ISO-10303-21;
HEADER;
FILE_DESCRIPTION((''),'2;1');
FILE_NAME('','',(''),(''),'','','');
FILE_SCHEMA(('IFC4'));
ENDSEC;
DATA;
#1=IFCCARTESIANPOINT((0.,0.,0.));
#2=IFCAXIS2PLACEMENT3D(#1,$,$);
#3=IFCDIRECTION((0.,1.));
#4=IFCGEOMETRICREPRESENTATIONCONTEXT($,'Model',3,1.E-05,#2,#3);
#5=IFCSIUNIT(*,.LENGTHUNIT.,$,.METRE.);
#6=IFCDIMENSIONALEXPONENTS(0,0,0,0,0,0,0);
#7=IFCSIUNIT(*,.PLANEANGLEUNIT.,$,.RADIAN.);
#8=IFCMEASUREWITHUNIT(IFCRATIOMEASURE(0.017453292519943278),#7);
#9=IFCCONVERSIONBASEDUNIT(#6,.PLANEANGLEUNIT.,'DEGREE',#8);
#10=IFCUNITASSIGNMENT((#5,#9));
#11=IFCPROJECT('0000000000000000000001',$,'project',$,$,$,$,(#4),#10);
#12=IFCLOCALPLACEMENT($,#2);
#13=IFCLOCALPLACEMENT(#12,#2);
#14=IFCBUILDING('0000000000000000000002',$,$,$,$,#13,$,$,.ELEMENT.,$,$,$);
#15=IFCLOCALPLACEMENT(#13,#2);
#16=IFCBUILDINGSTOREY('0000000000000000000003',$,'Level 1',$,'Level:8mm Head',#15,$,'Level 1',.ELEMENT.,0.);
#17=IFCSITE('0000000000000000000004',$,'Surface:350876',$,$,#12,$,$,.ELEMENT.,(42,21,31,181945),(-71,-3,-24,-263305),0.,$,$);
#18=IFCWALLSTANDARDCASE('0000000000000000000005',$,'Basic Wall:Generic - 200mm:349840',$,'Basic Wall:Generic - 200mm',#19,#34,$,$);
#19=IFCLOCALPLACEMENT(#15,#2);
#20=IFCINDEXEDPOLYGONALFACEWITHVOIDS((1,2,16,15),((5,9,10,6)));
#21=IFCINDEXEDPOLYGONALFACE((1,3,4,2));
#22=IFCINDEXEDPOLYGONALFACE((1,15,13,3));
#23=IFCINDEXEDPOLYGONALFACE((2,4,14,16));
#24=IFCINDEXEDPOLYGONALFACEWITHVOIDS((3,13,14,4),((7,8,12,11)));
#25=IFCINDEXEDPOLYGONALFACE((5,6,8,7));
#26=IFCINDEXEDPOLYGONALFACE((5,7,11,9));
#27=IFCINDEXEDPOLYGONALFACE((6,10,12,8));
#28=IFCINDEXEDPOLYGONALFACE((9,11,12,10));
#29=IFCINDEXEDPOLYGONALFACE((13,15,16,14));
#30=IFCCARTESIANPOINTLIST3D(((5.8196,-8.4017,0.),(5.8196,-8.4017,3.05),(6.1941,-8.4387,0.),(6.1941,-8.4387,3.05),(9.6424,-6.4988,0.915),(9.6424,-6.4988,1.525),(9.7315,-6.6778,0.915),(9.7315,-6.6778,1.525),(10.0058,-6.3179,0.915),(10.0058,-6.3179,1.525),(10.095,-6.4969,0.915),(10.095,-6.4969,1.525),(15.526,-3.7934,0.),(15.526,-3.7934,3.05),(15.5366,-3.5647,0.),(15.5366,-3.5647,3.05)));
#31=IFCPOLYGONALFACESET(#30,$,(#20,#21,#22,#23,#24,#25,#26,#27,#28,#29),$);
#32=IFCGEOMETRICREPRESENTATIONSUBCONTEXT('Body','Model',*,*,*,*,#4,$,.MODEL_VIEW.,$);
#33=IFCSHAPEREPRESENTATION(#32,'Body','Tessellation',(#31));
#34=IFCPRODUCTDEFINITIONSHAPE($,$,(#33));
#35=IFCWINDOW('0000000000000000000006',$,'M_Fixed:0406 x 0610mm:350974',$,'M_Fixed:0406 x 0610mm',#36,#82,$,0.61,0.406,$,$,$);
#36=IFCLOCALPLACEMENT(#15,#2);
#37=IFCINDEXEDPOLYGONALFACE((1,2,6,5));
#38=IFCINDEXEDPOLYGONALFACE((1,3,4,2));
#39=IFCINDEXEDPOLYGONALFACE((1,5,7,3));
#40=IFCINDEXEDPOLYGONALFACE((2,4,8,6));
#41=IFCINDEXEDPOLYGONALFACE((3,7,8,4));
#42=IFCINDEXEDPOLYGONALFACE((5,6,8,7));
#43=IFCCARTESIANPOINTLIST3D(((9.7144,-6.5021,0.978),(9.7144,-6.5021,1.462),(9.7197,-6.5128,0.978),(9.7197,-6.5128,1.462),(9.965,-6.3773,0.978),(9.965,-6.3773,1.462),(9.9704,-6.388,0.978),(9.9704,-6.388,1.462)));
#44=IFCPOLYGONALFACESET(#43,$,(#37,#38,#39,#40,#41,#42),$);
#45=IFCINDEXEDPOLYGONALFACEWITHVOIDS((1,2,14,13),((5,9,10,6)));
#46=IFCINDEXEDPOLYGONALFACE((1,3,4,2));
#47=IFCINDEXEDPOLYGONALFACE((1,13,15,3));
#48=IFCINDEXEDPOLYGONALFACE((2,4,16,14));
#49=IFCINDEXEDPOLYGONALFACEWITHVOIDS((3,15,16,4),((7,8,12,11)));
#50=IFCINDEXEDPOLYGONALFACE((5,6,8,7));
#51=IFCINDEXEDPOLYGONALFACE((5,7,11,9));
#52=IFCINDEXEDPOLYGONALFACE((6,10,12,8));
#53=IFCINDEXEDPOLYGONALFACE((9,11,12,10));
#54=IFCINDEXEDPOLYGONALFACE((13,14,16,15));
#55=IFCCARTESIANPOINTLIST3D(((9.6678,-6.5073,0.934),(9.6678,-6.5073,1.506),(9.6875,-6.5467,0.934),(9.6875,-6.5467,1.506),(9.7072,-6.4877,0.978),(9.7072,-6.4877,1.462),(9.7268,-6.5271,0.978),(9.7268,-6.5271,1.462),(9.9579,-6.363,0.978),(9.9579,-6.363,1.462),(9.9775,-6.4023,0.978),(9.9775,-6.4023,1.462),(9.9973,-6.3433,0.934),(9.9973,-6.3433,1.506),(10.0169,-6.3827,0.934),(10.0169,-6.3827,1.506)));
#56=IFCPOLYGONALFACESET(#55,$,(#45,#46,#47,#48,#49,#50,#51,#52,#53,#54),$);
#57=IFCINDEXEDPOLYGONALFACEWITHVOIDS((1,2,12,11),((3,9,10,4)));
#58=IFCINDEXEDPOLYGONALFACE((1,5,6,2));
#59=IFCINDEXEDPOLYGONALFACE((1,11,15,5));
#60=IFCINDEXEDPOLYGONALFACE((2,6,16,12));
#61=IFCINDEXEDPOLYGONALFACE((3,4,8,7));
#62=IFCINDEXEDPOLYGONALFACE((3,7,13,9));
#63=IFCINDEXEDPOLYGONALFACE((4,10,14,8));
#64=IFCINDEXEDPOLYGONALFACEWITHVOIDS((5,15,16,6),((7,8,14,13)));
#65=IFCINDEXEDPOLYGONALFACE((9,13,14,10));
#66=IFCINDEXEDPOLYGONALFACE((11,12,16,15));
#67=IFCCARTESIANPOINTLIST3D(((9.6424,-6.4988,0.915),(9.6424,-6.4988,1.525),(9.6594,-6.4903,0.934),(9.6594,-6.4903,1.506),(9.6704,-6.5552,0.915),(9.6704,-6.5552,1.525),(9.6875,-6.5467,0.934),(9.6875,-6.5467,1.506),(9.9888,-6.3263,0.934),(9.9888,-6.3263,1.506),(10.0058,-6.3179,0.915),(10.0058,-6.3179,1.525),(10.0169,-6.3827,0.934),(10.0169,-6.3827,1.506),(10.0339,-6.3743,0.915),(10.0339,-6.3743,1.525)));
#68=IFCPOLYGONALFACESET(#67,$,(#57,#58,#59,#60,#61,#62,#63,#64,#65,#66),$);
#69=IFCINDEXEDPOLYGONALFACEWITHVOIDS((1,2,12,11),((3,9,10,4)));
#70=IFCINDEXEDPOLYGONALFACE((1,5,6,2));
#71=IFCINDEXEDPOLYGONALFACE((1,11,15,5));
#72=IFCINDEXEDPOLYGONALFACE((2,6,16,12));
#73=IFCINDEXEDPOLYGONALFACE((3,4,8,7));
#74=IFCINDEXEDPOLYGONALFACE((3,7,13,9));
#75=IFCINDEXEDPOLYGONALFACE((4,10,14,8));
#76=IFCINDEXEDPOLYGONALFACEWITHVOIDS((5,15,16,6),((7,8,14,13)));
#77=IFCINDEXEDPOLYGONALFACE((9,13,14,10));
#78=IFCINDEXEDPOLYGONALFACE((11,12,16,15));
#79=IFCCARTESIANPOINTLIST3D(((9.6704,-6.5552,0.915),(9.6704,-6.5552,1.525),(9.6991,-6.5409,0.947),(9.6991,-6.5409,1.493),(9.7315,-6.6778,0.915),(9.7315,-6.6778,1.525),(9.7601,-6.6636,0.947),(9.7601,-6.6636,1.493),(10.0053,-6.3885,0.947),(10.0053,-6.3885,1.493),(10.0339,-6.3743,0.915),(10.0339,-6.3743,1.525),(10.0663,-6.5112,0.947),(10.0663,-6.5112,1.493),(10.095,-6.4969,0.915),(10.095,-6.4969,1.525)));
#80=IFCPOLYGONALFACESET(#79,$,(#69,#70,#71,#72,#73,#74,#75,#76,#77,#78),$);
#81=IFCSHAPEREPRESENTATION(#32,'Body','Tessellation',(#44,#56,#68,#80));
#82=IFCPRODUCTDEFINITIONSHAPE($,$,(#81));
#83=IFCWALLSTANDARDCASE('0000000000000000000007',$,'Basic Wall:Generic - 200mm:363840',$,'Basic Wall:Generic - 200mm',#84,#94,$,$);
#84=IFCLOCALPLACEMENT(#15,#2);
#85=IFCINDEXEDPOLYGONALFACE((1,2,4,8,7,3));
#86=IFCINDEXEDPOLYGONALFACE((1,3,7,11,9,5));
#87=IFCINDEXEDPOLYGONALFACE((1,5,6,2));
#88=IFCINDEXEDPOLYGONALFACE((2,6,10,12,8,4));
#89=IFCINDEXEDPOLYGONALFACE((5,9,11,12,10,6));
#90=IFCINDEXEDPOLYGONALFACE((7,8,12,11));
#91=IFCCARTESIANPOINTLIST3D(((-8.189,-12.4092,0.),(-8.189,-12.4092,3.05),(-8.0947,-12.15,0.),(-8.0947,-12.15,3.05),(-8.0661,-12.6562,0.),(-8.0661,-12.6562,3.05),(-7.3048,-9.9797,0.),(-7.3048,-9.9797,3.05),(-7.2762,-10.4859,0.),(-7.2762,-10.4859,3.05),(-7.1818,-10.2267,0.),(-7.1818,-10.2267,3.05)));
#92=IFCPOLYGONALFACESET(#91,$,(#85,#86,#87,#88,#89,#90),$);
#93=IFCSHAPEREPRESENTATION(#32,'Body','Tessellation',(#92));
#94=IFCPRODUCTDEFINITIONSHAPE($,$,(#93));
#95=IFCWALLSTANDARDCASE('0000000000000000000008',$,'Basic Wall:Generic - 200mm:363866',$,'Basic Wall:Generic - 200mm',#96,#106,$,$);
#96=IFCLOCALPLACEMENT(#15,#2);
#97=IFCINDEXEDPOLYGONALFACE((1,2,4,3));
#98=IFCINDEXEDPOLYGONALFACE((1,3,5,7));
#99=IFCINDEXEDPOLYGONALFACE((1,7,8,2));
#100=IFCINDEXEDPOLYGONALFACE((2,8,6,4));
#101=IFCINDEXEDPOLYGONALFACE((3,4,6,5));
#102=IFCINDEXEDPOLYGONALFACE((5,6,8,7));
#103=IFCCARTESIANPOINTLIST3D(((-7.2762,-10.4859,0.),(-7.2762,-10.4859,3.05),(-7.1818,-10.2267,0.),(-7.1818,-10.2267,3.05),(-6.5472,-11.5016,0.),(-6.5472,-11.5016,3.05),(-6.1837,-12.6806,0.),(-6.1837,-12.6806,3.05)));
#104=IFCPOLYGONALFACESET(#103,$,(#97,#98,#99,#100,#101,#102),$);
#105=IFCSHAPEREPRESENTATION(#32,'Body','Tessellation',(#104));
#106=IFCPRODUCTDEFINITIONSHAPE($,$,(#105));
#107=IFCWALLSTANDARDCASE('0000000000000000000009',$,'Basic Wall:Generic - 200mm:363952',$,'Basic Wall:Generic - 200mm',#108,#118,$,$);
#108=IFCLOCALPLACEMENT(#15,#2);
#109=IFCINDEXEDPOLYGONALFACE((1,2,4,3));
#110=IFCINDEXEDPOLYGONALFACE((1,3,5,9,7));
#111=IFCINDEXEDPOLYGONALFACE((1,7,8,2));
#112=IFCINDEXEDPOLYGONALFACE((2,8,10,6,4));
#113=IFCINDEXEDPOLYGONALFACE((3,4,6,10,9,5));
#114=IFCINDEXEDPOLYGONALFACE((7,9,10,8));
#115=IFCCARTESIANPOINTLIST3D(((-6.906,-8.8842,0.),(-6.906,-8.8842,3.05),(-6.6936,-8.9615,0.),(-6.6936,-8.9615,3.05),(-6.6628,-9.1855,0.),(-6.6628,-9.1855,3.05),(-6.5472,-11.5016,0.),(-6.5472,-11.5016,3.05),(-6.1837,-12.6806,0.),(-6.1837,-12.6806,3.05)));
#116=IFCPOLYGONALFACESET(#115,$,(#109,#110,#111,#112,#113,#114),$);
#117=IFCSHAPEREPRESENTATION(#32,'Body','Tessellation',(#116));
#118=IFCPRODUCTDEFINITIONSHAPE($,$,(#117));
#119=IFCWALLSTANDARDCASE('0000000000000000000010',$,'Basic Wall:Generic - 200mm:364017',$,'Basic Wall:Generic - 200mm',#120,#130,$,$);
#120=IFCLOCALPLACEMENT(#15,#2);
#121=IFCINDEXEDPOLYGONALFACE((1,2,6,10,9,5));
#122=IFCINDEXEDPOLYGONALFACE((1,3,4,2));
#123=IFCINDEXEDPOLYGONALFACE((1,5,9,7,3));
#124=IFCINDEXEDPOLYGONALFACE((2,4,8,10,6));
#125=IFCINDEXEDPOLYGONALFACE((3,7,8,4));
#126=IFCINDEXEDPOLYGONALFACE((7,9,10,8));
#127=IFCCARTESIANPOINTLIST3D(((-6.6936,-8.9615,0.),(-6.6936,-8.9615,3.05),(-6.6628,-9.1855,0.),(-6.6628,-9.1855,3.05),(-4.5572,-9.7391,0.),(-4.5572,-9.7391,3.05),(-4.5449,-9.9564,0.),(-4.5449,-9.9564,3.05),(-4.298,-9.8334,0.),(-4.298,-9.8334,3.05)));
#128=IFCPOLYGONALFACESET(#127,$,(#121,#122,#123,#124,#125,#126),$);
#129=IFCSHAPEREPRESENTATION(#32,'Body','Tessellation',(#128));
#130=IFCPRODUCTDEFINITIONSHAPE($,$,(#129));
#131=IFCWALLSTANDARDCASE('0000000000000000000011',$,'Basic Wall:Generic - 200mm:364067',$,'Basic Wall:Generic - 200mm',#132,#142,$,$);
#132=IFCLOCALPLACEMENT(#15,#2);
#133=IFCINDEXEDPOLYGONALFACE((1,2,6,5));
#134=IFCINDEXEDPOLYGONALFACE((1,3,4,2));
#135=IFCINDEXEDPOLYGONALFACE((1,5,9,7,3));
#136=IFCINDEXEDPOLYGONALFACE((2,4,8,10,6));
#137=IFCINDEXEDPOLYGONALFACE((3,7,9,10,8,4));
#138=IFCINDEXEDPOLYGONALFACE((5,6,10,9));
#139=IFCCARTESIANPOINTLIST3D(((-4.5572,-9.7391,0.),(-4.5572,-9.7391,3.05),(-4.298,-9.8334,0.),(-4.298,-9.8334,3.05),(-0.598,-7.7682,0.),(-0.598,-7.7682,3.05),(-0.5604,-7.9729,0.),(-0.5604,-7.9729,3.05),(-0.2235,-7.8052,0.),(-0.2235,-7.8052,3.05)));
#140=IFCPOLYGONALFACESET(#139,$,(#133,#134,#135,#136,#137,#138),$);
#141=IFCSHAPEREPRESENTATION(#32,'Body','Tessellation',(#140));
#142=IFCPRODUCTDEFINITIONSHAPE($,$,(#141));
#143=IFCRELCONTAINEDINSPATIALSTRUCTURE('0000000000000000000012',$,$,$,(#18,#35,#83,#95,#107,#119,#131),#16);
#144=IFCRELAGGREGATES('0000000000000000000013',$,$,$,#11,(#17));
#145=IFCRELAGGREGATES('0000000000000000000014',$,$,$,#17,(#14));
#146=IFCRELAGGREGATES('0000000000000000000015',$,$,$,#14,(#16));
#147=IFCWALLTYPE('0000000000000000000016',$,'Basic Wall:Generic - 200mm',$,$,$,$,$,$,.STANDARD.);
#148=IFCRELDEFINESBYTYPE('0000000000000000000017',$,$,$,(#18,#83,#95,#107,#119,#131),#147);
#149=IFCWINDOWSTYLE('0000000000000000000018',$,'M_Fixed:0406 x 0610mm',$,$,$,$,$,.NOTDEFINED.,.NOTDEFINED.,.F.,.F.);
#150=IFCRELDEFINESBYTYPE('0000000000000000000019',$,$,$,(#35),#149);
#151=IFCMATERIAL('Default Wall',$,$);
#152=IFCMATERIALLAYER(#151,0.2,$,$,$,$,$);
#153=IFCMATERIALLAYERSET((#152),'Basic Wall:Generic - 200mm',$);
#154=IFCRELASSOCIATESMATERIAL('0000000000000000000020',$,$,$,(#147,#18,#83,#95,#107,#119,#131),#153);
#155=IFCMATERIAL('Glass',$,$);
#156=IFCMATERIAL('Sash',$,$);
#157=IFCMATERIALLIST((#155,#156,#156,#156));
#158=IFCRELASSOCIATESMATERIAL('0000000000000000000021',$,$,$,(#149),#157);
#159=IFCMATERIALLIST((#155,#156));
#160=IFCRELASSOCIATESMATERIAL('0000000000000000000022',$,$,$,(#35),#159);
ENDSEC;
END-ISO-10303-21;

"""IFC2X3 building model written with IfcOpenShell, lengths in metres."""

from ifc_helpers import new_model, entity, si_unit, converted_unit, direction, frame, frame_2d, origin, place, context, subcontext, project, spatial, polyline, rectangle, outline, extrude, source, transform, mapped, material, material_list, layer, layer_set, layer_usage, type_object, type_shapes, element, fill, save


model = new_model("IFC2X3")

# Units and contexts
model_context = context("Model", 3, precision=1e-05, world=origin(), true_north=direction((0.0, 1.0)))
body_context = subcontext(model_context, "Body", "Model", "MODEL_VIEW")
ifc_project = project(units=[si_unit("LENGTHUNIT", "METRE"), converted_unit("PLANEANGLEUNIT", "DEGREE", entity("IfcRatioMeasure", 0.017453292519943278), si_unit("PLANEANGLEUNIT", "RADIAN"), dimensions=[0, 0, 0, 0, 0, 0, 0])], contexts=[model_context])

# Site, building, storey
site_placement = place(None, origin())
site = spatial("IfcSite", under=ifc_project, at=site_placement, Name="Surface:350876", CompositionType="ELEMENT", RefLatitude=(42, 21, 31, 181945), RefLongitude=(-71, -3, -24, -263305), RefElevation=0.0)
building_placement = place(site_placement, origin())
building = spatial("IfcBuilding", under=site, at=building_placement, CompositionType="ELEMENT")
storey_placement = place(building_placement, origin())
storey = spatial("IfcBuildingStorey", under=building, at=storey_placement, Name="Level 1", ObjectType="Level:8mm Head", LongName="Level 1", CompositionType="ELEMENT", Elevation=0.0)

# Wall, opening, window
ifc_material_1 = material(Name="Default Wall")
ifc_layer_1 = layer(ifc_material_1, 0.2)
ifc_layer_set_1 = layer_set([ifc_layer_1], Name="Basic Wall:Generic - 200mm")
ifc_layer_usage_1 = layer_usage(ifc_layer_set_1, "AXIS2", "NEGATIVE", 0.1)
wall_type_1 = type_object("IfcWallType", Name="Basic Wall:Generic - 200mm", PredefinedType="STANDARD", material=ifc_layer_set_1)
wall_1_placement = place(storey_placement, frame((5.8642, -8.4912, 0.0), z_axis=(0.0, 0.0, 1.0), x_axis=(0.895217, 0.44563, 0.0)))
wall_1 = element("IfcWallStandardCase", 1, at=wall_1_placement, inside=storey, type_object=wall_type_1, material=ifc_layer_usage_1, Name="Basic Wall:Generic - 200mm:349840", ObjectType="Basic Wall:Generic - 200mm", context=body_context, shape_type="SweptSolid", body=[
    extrude(outline(polyline([(10.7429, -0.1), (10.8544, 0.1), (10.6254, 0.1), (9.4635, 0.1), (9.2633, 0.1), (0.1742, 0.1), (0.0, 0.1), (0.3188, -0.1), (10.7429, -0.1)])), origin(), (0.0, 0.0, 1.0), 3.05),
])
opening_1_placement = place(wall_1_placement, frame((4.2702, -0.1, 0.915)))
opening_1 = element("IfcOpeningElement", 2, at=opening_1_placement, cuts=wall_1, ObjectType="Opening", context=body_context, shape_type="SweptSolid", body=[
    extrude(rectangle(XDim=0.61, YDim=0.406, at=frame_2d((0.305, 0.203), x_axis=(1.0, 0.0))), frame((0.0, 0.0, 0.0), z_axis=(0.0, 1.0, 0.0), x_axis=(0.0, 0.0, 1.0)), (0.0, 0.0, 1.0), 0.2),
])
ifc_material_2 = material(Name="Glass")
ifc_material_3 = material(Name="Sash")
ifc_material_list_1 = material_list([ifc_material_2, ifc_material_3])
ifc_material_list_2 = material_list([ifc_material_2, ifc_material_3, ifc_material_3, ifc_material_3])
window_style = type_object("IfcWindowStyle", Name="M_Fixed:0406 x 0610mm", ConstructionType="NOTDEFINED", OperationType="NOTDEFINED", ParameterTakesPrecedence=False, Sizeable=False, material=ifc_material_list_2)
shared_shape_1 = source(origin(), body_context, "Body", "SweptSolid", [
    extrude(rectangle(XDim=0.012, YDim=0.28, at=frame_2d((0.0, 0.0), x_axis=(1.0, 0.0))), frame((0.203, 0.159, 0.063), z_axis=(0.0, 0.0, 1.0), x_axis=(0.0, -1.0, 0.0)), (0.0, 0.0, 1.0), 0.484),
    extrude(outline(polyline([(-0.184, -0.286), (0.184, -0.286), (0.184, 0.286), (-0.184, 0.286), (-0.184, -0.286)]), holes=[polyline([(-0.14, -0.242), (-0.14, 0.242), (0.14, 0.242), (0.14, -0.242), (-0.14, -0.242)])]), frame((0.203, 0.137, 0.305), z_axis=(0.0, 1.0, 0.0), x_axis=(1.0, 0.0, 0.0)), (0.0, 0.0, 1.0), 0.044),
    extrude(outline(polyline([(-0.203, -0.305), (0.203, -0.305), (0.203, 0.305), (-0.203, 0.305), (-0.203, -0.305)]), holes=[polyline([(-0.184, -0.286), (-0.184, 0.286), (0.184, 0.286), (0.184, -0.286), (-0.184, -0.286)])]), frame((0.203, 0.137, 0.305), z_axis=(0.0, 1.0, 0.0), x_axis=(1.0, 0.0, 0.0)), (0.0, 0.0, 1.0), 0.063),
    extrude(outline(polyline([(-0.203, -0.305), (0.203, -0.305), (0.203, 0.305), (-0.203, 0.305), (-0.203, -0.305)]), holes=[polyline([(-0.171, -0.273), (-0.171, 0.273), (0.171, 0.273), (0.171, -0.273), (-0.171, -0.273)])]), frame((0.203, 0.0, 0.305), z_axis=(0.0, 1.0, 0.0), x_axis=(1.0, 0.0, 0.0)), (0.0, 0.0, 1.0), 0.137),
])
type_shapes(window_style, [shared_shape_1])
window_1_placement = place(opening_1_placement, origin())
window_1 = element("IfcWindow", 3, at=window_1_placement, inside=storey, type_object=window_style, material=ifc_material_list_1, Name="M_Fixed:0406 x 0610mm:350974", ObjectType="M_Fixed:0406 x 0610mm", OverallHeight=0.61, OverallWidth=0.406, context=body_context, shape_type="MappedRepresentation", body=[
    mapped(shared_shape_1, transform((0.0, 0.0, 0.0), scale=1.0)),
])
fill(opening_1, window_1)

# Walls
ifc_layer_usage_2 = layer_usage(ifc_layer_set_1, "AXIS2", "NEGATIVE", 0.1)
wall_2_placement = place(storey_placement, frame((-8.1601, -12.622, 0.0), z_axis=(0.0, 0.0, 1.0), x_axis=(0.34202, 0.939693, 0.0)))
element("IfcWallStandardCase", 4, at=wall_2_placement, inside=storey, type_object=wall_type_1, material=ifc_layer_usage_2, Name="Basic Wall:Generic - 200mm:363840", ObjectType="Basic Wall:Generic - 200mm", context=body_context, shape_type="SweptSolid", body=[
    extrude(outline(polyline([(2.5855, -0.1), (2.7755, 0.1), (0.4659, 0.1), (0.19, 0.1), (0.0, -0.1), (2.3096, -0.1), (2.5855, -0.1)])), origin(), (0.0, 0.0, 1.0), 3.05),
])
ifc_layer_usage_3 = layer_usage(ifc_layer_set_1, "AXIS2", "NEGATIVE", 0.1)
wall_3_placement = place(storey_placement, frame((-7.2713, -10.2712, 0.0), z_axis=(0.0, 0.0, 1.0), x_axis=(0.44563, -0.895217, 0.0)))
element("IfcWallStandardCase", 5, at=wall_3_placement, inside=storey, type_object=wall_type_1, material=ifc_layer_usage_3, Name="Basic Wall:Generic - 200mm:363866", ObjectType="Basic Wall:Generic - 200mm", context=body_context, shape_type="SweptSolid", body=[
    extrude(outline(polyline([(2.6416, -0.1), (1.4241, 0.1), (0.0, 0.1), (0.19, -0.1), (2.6416, -0.1)])), origin(), (0.0, 0.0, 1.0), 3.05),
])
ifc_layer_usage_4 = layer_usage(ifc_layer_set_1, "AXIS2", "NEGATIVE", 0.1)
wall_4_placement = place(storey_placement, frame((-6.2828, -12.6942, 0.0), z_axis=(0.0, 0.0, 1.0), x_axis=(-0.135824, 0.990733, 0.0)))
element("IfcWallStandardCase", 6, at=wall_4_placement, inside=storey, type_object=wall_type_1, material=ifc_layer_usage_4, Name="Basic Wall:Generic - 200mm:363952", ObjectType="Basic Wall:Generic - 200mm", context=body_context, shape_type="SweptSolid", body=[
    extrude(outline(polyline([(3.7539, -0.1), (3.8594, 0.1), (1.2175, 0.1), (0.0, -0.1), (3.5278, -0.1), (3.7539, -0.1)])), origin(), (0.0, 0.0, 1.0), 3.05),
])
ifc_layer_usage_5 = layer_usage(ifc_layer_set_1, "AXIS2", "NEGATIVE", 0.1)
wall_5_placement = place(storey_placement, frame((-6.7278, -9.0555, 0.0), z_axis=(0.0, 0.0, 1.0), x_axis=(0.939693, -0.34202, 0.0)))
element("IfcWallStandardCase", 7, at=wall_5_placement, inside=storey, type_object=wall_type_1, material=ifc_layer_usage_5, Name="Basic Wall:Generic - 200mm:364017", ObjectType="Basic Wall:Generic - 200mm", context=body_context, shape_type="SweptSolid", body=[
    extrude(outline(polyline([(2.3593, -0.1), (2.5493, 0.1), (2.2734, 0.1), (0.0, 0.1), (0.1055, -0.1), (2.3593, -0.1)])), origin(), (0.0, 0.0, 1.0), 3.05),
])
ifc_layer_usage_6 = layer_usage(ifc_layer_set_1, "AXIS2", "NEGATIVE", 0.1)
wall_6_placement = place(storey_placement, frame((-4.5126, -9.8286, 0.0), z_axis=(0.0, 0.0, 1.0), x_axis=(0.895217, 0.44563, 0.0)))
element("IfcWallStandardCase", 8, at=wall_6_placement, inside=storey, type_object=wall_type_1, material=ifc_layer_usage_6, Name="Basic Wall:Generic - 200mm:364067", ObjectType="Basic Wall:Generic - 200mm", context=body_context, shape_type="SweptSolid", body=[
    extrude(outline(polyline([(4.7414, -0.1), (4.4226, 0.1), (0.0, 0.1), (0.19, -0.1), (4.3651, -0.1), (4.7414, -0.1)])), origin(), (0.0, 0.0, 1.0), 3.05),
])

save(model, "model.ifc")
